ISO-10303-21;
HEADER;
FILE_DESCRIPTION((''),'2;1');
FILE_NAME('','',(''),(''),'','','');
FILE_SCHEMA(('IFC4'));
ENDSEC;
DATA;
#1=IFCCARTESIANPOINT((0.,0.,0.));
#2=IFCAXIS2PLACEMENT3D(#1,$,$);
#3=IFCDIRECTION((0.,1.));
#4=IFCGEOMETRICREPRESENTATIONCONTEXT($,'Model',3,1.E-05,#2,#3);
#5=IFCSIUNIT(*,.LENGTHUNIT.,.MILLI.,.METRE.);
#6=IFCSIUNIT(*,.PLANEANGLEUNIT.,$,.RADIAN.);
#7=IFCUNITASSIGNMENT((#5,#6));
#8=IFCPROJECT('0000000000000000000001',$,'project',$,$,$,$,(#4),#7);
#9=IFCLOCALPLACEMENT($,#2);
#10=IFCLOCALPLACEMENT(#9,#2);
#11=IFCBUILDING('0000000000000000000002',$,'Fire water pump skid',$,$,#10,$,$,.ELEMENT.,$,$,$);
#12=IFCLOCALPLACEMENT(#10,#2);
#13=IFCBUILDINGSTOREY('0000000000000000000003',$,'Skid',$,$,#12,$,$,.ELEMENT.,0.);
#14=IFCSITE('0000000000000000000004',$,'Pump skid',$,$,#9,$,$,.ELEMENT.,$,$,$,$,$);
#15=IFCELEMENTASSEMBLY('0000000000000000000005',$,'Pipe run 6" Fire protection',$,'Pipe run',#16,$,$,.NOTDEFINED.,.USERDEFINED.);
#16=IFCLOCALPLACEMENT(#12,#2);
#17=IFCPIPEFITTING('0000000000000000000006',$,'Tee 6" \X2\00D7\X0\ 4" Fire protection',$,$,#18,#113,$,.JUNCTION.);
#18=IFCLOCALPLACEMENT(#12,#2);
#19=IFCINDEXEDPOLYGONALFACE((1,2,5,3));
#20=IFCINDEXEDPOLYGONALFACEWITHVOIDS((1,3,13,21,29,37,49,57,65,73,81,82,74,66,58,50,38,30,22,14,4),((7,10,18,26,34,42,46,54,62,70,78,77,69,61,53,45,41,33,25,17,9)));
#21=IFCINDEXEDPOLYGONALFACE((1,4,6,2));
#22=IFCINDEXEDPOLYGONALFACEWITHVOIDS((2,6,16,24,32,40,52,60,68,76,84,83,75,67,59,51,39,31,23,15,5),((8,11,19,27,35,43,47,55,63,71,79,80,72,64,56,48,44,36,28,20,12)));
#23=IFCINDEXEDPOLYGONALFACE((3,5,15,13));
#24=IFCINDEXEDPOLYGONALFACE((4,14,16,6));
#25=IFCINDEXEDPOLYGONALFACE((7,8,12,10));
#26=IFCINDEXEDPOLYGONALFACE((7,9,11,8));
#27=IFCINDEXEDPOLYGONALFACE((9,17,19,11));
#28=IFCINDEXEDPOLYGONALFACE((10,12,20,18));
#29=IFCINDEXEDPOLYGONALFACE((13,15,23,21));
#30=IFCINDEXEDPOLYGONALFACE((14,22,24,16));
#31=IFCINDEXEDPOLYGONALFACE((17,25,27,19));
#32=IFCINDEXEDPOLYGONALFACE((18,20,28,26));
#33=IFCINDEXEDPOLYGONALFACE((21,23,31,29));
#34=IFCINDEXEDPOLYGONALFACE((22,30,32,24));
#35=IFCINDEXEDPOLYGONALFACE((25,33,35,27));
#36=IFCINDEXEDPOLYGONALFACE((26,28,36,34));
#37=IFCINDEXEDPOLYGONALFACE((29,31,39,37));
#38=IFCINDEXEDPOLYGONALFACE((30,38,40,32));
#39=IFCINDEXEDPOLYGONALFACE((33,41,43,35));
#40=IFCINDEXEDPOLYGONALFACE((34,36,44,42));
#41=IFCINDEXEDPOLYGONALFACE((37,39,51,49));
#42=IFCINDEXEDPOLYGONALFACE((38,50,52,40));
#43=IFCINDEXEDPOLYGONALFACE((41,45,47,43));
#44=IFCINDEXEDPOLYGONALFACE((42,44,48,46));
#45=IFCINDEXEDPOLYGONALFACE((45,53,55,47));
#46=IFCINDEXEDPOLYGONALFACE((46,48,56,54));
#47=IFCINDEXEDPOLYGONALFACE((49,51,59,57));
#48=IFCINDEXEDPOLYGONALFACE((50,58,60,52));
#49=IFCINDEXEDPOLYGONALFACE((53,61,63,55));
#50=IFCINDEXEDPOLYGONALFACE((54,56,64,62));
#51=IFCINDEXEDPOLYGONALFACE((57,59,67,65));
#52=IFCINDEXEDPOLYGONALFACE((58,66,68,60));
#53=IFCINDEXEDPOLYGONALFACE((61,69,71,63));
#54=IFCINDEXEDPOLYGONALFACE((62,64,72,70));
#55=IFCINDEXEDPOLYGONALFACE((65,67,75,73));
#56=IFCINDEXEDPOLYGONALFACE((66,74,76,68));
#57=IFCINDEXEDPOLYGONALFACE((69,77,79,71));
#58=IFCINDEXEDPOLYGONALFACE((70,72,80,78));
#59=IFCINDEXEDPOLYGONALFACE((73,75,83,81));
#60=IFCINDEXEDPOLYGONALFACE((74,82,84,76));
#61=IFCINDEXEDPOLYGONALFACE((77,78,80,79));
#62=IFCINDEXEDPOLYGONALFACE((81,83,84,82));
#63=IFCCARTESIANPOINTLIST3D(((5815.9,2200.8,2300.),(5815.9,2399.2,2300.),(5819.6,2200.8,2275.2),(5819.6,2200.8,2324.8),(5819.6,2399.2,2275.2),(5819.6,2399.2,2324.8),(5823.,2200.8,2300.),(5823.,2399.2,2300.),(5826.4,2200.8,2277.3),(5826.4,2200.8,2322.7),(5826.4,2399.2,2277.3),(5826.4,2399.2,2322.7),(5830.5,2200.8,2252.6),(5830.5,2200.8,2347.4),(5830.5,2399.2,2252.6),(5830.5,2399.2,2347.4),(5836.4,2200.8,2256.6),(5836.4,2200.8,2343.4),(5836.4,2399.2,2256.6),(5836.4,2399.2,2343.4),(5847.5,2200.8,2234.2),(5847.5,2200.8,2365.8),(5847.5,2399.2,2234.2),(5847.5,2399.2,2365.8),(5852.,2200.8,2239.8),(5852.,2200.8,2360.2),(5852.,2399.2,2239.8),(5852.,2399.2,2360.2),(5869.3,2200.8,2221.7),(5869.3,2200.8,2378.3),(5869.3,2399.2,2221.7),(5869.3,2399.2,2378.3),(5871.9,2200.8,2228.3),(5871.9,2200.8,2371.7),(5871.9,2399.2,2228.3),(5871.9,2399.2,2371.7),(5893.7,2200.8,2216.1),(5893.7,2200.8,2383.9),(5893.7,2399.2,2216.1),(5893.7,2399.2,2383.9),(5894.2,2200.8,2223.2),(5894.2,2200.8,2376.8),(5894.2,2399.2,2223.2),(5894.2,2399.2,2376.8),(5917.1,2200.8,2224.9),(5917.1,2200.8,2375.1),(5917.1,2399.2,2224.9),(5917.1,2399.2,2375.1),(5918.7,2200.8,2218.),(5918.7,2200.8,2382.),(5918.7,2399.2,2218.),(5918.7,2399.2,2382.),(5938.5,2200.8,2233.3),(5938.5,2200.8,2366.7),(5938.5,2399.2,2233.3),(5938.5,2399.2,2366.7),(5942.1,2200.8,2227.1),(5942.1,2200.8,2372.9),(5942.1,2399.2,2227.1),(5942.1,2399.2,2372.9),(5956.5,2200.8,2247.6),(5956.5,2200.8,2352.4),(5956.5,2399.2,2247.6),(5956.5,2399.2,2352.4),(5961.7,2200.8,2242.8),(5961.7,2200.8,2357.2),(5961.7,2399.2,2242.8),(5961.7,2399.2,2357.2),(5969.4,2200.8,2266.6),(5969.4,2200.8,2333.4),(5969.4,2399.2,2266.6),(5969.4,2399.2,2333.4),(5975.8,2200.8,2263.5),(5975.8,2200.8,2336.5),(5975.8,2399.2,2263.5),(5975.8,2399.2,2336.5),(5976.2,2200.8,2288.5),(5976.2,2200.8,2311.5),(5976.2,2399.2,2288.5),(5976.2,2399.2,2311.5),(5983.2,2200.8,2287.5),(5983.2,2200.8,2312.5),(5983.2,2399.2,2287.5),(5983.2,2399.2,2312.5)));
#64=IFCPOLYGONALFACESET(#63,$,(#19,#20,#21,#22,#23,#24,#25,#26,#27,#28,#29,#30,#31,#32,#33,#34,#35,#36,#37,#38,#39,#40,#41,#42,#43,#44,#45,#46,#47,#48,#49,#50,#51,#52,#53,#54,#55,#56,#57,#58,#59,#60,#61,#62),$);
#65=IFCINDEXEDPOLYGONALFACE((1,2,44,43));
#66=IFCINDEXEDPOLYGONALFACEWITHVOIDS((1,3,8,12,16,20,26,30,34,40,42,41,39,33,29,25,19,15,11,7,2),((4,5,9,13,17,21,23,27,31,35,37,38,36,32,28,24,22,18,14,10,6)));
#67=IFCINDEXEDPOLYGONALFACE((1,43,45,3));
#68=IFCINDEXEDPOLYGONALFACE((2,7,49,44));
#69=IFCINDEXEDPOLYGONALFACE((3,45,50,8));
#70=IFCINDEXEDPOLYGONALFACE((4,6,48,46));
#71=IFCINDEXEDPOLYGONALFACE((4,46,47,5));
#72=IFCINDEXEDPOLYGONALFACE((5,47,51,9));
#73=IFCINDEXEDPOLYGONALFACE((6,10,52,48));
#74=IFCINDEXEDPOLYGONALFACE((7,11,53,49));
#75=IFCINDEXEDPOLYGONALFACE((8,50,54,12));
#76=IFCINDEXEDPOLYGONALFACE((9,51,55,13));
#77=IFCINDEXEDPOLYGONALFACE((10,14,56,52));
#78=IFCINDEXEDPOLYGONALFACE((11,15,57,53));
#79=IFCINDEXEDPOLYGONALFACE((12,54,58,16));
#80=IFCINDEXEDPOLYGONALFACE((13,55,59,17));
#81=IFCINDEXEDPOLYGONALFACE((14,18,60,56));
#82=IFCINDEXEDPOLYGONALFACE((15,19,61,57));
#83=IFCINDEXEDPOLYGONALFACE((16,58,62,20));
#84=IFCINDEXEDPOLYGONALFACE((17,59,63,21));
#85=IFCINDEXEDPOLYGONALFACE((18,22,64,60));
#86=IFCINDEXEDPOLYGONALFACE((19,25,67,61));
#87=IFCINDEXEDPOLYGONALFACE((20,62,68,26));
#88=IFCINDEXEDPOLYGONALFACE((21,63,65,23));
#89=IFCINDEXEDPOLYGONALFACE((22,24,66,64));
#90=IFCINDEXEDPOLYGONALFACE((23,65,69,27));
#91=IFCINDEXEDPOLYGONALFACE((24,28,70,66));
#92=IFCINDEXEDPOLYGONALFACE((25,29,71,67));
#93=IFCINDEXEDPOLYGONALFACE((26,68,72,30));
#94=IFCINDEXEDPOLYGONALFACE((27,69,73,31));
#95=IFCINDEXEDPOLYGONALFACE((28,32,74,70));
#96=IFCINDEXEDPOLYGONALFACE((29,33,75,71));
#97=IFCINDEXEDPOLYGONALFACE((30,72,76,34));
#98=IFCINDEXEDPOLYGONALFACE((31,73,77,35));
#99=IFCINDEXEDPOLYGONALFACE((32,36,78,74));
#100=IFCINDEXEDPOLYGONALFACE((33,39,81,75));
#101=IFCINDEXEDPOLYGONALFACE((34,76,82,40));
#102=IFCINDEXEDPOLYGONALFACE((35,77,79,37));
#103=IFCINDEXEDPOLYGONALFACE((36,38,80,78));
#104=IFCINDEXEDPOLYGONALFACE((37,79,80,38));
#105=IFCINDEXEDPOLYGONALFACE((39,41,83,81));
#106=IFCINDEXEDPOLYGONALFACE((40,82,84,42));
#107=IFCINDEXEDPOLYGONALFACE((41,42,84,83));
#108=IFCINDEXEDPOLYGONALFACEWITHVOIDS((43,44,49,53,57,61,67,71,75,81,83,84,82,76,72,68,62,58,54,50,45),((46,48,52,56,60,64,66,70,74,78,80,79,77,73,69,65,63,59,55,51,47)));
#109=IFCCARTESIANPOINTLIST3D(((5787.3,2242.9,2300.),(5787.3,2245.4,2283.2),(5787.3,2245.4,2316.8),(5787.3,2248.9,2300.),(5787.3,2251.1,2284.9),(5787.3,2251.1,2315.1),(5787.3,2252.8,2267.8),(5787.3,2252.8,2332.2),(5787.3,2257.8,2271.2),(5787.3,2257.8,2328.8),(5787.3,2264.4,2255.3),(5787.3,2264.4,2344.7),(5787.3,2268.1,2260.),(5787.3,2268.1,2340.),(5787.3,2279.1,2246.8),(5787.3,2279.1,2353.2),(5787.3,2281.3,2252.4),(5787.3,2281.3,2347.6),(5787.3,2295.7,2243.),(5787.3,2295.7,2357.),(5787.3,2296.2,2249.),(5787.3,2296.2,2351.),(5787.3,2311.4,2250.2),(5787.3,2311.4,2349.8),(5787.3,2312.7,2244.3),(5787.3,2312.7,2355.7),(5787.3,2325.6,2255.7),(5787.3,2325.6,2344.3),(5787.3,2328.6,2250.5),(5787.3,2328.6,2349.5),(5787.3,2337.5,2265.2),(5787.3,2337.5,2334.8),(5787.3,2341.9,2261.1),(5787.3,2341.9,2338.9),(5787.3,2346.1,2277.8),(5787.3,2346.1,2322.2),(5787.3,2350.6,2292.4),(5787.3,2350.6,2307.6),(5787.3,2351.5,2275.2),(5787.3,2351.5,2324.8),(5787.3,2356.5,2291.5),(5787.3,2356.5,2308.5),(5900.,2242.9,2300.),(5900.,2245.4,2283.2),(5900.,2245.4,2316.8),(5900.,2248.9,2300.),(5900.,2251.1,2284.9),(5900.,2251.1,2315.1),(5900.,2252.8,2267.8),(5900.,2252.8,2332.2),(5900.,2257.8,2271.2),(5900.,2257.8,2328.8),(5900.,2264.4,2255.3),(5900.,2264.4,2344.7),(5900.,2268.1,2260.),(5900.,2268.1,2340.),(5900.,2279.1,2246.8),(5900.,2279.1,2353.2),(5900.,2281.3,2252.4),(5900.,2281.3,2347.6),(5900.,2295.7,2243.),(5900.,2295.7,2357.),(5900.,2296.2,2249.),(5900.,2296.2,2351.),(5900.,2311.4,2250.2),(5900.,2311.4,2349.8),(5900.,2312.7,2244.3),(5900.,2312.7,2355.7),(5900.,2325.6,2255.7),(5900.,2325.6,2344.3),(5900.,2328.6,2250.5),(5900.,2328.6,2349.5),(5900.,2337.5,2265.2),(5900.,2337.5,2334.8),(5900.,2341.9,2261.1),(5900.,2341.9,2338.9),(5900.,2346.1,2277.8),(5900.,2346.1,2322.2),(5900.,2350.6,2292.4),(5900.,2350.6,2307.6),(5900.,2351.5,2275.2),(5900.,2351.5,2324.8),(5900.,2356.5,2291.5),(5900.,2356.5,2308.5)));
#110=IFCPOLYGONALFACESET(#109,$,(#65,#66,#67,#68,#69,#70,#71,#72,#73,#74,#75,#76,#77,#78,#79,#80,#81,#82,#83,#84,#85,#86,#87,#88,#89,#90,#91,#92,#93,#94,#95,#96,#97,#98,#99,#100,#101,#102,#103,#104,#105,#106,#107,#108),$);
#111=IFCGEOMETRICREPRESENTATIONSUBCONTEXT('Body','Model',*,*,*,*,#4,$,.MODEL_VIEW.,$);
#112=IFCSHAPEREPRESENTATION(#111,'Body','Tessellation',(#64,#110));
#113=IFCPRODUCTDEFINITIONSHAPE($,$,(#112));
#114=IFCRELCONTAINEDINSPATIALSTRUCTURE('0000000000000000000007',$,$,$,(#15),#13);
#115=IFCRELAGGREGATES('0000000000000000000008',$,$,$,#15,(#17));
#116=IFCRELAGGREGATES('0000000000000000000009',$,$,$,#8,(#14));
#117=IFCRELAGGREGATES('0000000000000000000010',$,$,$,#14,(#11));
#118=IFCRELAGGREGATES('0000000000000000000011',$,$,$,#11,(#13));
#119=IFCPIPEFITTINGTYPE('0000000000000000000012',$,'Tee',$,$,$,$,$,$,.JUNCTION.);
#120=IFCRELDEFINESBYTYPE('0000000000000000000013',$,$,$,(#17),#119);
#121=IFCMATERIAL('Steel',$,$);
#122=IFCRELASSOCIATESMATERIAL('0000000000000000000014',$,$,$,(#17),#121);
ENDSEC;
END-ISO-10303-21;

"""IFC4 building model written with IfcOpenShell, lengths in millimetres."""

from ifc_helpers import new_model, si_unit, direction, frame, origin, origin_with_axes, origin_2d, place, context, subcontext, project, spatial, hollow_circle, extrude, material, type_object, element, aggregate, save


model = new_model("IFC4")

# Units and contexts
model_context = context("Model", 3, precision=1e-05, world=origin(), true_north=direction((0.0, 1.0)))
body_context = subcontext(model_context, "Body", "Model", "MODEL_VIEW")
ifc_project = project(units=[si_unit("LENGTHUNIT", "METRE", prefix="MILLI"), si_unit("PLANEANGLEUNIT", "RADIAN")], contexts=[model_context])

# Site, building, storey
site_placement = place(None, origin())
site = spatial("IfcSite", under=ifc_project, at=site_placement, Name="Pump skid", CompositionType="ELEMENT")
building_placement = place(site_placement, origin())
building = spatial("IfcBuilding", under=site, at=building_placement, Name="Fire water pump skid", CompositionType="ELEMENT")
storey_placement = place(building_placement, origin())
storey = spatial("IfcBuildingStorey", under=building, at=storey_placement, Name="Skid", CompositionType="ELEMENT", Elevation=0.0)

# Element assembly
ifc_material = material(Name="Steel")
assembly_1_placement = place(storey_placement, origin_with_axes())
assembly_1 = element("IfcElementAssembly", 1, at=assembly_1_placement, inside=storey, Name="Pipe run 6\" Fire protection", ObjectType="Pipe run", AssemblyPlace="NOTDEFINED", PredefinedType="USERDEFINED")

# Pipe fitting
pipe_fitting_type_1 = type_object("IfcPipeFittingType", Name="Tee", PredefinedType="JUNCTION")
pipe_fitting_1_placement = place(storey_placement, origin_with_axes())
pipe_fitting_1 = element("IfcPipeFitting", 2, at=pipe_fitting_1_placement, type_object=pipe_fitting_type_1, material=ifc_material, Name="Tee 6\" × 4\" Fire protection", PredefinedType="JUNCTION", context=body_context, shape_type="SweptSolid", body=[
    extrude(hollow_circle(Radius=84.1, WallThickness=7.1, at=origin_2d()), frame((5900.0, 2200.8, 2300.0), z_axis=(0.0, 1.0, 0.0), x_axis=(-1.0, 0.0, 0.0)), (0.0, 0.0, 1.0), 198.4),
    extrude(hollow_circle(Radius=57.1, WallThickness=6.0, at=origin_2d()), frame((5900.0, 2300.0, 2300.0), z_axis=(-1.0, 0.0, 0.0), x_axis=(0.0, -1.0, 0.0)), (0.0, 0.0, 1.0), 112.7),
])
aggregate(assembly_1, [pipe_fitting_1])

save(model, "model.ifc")
